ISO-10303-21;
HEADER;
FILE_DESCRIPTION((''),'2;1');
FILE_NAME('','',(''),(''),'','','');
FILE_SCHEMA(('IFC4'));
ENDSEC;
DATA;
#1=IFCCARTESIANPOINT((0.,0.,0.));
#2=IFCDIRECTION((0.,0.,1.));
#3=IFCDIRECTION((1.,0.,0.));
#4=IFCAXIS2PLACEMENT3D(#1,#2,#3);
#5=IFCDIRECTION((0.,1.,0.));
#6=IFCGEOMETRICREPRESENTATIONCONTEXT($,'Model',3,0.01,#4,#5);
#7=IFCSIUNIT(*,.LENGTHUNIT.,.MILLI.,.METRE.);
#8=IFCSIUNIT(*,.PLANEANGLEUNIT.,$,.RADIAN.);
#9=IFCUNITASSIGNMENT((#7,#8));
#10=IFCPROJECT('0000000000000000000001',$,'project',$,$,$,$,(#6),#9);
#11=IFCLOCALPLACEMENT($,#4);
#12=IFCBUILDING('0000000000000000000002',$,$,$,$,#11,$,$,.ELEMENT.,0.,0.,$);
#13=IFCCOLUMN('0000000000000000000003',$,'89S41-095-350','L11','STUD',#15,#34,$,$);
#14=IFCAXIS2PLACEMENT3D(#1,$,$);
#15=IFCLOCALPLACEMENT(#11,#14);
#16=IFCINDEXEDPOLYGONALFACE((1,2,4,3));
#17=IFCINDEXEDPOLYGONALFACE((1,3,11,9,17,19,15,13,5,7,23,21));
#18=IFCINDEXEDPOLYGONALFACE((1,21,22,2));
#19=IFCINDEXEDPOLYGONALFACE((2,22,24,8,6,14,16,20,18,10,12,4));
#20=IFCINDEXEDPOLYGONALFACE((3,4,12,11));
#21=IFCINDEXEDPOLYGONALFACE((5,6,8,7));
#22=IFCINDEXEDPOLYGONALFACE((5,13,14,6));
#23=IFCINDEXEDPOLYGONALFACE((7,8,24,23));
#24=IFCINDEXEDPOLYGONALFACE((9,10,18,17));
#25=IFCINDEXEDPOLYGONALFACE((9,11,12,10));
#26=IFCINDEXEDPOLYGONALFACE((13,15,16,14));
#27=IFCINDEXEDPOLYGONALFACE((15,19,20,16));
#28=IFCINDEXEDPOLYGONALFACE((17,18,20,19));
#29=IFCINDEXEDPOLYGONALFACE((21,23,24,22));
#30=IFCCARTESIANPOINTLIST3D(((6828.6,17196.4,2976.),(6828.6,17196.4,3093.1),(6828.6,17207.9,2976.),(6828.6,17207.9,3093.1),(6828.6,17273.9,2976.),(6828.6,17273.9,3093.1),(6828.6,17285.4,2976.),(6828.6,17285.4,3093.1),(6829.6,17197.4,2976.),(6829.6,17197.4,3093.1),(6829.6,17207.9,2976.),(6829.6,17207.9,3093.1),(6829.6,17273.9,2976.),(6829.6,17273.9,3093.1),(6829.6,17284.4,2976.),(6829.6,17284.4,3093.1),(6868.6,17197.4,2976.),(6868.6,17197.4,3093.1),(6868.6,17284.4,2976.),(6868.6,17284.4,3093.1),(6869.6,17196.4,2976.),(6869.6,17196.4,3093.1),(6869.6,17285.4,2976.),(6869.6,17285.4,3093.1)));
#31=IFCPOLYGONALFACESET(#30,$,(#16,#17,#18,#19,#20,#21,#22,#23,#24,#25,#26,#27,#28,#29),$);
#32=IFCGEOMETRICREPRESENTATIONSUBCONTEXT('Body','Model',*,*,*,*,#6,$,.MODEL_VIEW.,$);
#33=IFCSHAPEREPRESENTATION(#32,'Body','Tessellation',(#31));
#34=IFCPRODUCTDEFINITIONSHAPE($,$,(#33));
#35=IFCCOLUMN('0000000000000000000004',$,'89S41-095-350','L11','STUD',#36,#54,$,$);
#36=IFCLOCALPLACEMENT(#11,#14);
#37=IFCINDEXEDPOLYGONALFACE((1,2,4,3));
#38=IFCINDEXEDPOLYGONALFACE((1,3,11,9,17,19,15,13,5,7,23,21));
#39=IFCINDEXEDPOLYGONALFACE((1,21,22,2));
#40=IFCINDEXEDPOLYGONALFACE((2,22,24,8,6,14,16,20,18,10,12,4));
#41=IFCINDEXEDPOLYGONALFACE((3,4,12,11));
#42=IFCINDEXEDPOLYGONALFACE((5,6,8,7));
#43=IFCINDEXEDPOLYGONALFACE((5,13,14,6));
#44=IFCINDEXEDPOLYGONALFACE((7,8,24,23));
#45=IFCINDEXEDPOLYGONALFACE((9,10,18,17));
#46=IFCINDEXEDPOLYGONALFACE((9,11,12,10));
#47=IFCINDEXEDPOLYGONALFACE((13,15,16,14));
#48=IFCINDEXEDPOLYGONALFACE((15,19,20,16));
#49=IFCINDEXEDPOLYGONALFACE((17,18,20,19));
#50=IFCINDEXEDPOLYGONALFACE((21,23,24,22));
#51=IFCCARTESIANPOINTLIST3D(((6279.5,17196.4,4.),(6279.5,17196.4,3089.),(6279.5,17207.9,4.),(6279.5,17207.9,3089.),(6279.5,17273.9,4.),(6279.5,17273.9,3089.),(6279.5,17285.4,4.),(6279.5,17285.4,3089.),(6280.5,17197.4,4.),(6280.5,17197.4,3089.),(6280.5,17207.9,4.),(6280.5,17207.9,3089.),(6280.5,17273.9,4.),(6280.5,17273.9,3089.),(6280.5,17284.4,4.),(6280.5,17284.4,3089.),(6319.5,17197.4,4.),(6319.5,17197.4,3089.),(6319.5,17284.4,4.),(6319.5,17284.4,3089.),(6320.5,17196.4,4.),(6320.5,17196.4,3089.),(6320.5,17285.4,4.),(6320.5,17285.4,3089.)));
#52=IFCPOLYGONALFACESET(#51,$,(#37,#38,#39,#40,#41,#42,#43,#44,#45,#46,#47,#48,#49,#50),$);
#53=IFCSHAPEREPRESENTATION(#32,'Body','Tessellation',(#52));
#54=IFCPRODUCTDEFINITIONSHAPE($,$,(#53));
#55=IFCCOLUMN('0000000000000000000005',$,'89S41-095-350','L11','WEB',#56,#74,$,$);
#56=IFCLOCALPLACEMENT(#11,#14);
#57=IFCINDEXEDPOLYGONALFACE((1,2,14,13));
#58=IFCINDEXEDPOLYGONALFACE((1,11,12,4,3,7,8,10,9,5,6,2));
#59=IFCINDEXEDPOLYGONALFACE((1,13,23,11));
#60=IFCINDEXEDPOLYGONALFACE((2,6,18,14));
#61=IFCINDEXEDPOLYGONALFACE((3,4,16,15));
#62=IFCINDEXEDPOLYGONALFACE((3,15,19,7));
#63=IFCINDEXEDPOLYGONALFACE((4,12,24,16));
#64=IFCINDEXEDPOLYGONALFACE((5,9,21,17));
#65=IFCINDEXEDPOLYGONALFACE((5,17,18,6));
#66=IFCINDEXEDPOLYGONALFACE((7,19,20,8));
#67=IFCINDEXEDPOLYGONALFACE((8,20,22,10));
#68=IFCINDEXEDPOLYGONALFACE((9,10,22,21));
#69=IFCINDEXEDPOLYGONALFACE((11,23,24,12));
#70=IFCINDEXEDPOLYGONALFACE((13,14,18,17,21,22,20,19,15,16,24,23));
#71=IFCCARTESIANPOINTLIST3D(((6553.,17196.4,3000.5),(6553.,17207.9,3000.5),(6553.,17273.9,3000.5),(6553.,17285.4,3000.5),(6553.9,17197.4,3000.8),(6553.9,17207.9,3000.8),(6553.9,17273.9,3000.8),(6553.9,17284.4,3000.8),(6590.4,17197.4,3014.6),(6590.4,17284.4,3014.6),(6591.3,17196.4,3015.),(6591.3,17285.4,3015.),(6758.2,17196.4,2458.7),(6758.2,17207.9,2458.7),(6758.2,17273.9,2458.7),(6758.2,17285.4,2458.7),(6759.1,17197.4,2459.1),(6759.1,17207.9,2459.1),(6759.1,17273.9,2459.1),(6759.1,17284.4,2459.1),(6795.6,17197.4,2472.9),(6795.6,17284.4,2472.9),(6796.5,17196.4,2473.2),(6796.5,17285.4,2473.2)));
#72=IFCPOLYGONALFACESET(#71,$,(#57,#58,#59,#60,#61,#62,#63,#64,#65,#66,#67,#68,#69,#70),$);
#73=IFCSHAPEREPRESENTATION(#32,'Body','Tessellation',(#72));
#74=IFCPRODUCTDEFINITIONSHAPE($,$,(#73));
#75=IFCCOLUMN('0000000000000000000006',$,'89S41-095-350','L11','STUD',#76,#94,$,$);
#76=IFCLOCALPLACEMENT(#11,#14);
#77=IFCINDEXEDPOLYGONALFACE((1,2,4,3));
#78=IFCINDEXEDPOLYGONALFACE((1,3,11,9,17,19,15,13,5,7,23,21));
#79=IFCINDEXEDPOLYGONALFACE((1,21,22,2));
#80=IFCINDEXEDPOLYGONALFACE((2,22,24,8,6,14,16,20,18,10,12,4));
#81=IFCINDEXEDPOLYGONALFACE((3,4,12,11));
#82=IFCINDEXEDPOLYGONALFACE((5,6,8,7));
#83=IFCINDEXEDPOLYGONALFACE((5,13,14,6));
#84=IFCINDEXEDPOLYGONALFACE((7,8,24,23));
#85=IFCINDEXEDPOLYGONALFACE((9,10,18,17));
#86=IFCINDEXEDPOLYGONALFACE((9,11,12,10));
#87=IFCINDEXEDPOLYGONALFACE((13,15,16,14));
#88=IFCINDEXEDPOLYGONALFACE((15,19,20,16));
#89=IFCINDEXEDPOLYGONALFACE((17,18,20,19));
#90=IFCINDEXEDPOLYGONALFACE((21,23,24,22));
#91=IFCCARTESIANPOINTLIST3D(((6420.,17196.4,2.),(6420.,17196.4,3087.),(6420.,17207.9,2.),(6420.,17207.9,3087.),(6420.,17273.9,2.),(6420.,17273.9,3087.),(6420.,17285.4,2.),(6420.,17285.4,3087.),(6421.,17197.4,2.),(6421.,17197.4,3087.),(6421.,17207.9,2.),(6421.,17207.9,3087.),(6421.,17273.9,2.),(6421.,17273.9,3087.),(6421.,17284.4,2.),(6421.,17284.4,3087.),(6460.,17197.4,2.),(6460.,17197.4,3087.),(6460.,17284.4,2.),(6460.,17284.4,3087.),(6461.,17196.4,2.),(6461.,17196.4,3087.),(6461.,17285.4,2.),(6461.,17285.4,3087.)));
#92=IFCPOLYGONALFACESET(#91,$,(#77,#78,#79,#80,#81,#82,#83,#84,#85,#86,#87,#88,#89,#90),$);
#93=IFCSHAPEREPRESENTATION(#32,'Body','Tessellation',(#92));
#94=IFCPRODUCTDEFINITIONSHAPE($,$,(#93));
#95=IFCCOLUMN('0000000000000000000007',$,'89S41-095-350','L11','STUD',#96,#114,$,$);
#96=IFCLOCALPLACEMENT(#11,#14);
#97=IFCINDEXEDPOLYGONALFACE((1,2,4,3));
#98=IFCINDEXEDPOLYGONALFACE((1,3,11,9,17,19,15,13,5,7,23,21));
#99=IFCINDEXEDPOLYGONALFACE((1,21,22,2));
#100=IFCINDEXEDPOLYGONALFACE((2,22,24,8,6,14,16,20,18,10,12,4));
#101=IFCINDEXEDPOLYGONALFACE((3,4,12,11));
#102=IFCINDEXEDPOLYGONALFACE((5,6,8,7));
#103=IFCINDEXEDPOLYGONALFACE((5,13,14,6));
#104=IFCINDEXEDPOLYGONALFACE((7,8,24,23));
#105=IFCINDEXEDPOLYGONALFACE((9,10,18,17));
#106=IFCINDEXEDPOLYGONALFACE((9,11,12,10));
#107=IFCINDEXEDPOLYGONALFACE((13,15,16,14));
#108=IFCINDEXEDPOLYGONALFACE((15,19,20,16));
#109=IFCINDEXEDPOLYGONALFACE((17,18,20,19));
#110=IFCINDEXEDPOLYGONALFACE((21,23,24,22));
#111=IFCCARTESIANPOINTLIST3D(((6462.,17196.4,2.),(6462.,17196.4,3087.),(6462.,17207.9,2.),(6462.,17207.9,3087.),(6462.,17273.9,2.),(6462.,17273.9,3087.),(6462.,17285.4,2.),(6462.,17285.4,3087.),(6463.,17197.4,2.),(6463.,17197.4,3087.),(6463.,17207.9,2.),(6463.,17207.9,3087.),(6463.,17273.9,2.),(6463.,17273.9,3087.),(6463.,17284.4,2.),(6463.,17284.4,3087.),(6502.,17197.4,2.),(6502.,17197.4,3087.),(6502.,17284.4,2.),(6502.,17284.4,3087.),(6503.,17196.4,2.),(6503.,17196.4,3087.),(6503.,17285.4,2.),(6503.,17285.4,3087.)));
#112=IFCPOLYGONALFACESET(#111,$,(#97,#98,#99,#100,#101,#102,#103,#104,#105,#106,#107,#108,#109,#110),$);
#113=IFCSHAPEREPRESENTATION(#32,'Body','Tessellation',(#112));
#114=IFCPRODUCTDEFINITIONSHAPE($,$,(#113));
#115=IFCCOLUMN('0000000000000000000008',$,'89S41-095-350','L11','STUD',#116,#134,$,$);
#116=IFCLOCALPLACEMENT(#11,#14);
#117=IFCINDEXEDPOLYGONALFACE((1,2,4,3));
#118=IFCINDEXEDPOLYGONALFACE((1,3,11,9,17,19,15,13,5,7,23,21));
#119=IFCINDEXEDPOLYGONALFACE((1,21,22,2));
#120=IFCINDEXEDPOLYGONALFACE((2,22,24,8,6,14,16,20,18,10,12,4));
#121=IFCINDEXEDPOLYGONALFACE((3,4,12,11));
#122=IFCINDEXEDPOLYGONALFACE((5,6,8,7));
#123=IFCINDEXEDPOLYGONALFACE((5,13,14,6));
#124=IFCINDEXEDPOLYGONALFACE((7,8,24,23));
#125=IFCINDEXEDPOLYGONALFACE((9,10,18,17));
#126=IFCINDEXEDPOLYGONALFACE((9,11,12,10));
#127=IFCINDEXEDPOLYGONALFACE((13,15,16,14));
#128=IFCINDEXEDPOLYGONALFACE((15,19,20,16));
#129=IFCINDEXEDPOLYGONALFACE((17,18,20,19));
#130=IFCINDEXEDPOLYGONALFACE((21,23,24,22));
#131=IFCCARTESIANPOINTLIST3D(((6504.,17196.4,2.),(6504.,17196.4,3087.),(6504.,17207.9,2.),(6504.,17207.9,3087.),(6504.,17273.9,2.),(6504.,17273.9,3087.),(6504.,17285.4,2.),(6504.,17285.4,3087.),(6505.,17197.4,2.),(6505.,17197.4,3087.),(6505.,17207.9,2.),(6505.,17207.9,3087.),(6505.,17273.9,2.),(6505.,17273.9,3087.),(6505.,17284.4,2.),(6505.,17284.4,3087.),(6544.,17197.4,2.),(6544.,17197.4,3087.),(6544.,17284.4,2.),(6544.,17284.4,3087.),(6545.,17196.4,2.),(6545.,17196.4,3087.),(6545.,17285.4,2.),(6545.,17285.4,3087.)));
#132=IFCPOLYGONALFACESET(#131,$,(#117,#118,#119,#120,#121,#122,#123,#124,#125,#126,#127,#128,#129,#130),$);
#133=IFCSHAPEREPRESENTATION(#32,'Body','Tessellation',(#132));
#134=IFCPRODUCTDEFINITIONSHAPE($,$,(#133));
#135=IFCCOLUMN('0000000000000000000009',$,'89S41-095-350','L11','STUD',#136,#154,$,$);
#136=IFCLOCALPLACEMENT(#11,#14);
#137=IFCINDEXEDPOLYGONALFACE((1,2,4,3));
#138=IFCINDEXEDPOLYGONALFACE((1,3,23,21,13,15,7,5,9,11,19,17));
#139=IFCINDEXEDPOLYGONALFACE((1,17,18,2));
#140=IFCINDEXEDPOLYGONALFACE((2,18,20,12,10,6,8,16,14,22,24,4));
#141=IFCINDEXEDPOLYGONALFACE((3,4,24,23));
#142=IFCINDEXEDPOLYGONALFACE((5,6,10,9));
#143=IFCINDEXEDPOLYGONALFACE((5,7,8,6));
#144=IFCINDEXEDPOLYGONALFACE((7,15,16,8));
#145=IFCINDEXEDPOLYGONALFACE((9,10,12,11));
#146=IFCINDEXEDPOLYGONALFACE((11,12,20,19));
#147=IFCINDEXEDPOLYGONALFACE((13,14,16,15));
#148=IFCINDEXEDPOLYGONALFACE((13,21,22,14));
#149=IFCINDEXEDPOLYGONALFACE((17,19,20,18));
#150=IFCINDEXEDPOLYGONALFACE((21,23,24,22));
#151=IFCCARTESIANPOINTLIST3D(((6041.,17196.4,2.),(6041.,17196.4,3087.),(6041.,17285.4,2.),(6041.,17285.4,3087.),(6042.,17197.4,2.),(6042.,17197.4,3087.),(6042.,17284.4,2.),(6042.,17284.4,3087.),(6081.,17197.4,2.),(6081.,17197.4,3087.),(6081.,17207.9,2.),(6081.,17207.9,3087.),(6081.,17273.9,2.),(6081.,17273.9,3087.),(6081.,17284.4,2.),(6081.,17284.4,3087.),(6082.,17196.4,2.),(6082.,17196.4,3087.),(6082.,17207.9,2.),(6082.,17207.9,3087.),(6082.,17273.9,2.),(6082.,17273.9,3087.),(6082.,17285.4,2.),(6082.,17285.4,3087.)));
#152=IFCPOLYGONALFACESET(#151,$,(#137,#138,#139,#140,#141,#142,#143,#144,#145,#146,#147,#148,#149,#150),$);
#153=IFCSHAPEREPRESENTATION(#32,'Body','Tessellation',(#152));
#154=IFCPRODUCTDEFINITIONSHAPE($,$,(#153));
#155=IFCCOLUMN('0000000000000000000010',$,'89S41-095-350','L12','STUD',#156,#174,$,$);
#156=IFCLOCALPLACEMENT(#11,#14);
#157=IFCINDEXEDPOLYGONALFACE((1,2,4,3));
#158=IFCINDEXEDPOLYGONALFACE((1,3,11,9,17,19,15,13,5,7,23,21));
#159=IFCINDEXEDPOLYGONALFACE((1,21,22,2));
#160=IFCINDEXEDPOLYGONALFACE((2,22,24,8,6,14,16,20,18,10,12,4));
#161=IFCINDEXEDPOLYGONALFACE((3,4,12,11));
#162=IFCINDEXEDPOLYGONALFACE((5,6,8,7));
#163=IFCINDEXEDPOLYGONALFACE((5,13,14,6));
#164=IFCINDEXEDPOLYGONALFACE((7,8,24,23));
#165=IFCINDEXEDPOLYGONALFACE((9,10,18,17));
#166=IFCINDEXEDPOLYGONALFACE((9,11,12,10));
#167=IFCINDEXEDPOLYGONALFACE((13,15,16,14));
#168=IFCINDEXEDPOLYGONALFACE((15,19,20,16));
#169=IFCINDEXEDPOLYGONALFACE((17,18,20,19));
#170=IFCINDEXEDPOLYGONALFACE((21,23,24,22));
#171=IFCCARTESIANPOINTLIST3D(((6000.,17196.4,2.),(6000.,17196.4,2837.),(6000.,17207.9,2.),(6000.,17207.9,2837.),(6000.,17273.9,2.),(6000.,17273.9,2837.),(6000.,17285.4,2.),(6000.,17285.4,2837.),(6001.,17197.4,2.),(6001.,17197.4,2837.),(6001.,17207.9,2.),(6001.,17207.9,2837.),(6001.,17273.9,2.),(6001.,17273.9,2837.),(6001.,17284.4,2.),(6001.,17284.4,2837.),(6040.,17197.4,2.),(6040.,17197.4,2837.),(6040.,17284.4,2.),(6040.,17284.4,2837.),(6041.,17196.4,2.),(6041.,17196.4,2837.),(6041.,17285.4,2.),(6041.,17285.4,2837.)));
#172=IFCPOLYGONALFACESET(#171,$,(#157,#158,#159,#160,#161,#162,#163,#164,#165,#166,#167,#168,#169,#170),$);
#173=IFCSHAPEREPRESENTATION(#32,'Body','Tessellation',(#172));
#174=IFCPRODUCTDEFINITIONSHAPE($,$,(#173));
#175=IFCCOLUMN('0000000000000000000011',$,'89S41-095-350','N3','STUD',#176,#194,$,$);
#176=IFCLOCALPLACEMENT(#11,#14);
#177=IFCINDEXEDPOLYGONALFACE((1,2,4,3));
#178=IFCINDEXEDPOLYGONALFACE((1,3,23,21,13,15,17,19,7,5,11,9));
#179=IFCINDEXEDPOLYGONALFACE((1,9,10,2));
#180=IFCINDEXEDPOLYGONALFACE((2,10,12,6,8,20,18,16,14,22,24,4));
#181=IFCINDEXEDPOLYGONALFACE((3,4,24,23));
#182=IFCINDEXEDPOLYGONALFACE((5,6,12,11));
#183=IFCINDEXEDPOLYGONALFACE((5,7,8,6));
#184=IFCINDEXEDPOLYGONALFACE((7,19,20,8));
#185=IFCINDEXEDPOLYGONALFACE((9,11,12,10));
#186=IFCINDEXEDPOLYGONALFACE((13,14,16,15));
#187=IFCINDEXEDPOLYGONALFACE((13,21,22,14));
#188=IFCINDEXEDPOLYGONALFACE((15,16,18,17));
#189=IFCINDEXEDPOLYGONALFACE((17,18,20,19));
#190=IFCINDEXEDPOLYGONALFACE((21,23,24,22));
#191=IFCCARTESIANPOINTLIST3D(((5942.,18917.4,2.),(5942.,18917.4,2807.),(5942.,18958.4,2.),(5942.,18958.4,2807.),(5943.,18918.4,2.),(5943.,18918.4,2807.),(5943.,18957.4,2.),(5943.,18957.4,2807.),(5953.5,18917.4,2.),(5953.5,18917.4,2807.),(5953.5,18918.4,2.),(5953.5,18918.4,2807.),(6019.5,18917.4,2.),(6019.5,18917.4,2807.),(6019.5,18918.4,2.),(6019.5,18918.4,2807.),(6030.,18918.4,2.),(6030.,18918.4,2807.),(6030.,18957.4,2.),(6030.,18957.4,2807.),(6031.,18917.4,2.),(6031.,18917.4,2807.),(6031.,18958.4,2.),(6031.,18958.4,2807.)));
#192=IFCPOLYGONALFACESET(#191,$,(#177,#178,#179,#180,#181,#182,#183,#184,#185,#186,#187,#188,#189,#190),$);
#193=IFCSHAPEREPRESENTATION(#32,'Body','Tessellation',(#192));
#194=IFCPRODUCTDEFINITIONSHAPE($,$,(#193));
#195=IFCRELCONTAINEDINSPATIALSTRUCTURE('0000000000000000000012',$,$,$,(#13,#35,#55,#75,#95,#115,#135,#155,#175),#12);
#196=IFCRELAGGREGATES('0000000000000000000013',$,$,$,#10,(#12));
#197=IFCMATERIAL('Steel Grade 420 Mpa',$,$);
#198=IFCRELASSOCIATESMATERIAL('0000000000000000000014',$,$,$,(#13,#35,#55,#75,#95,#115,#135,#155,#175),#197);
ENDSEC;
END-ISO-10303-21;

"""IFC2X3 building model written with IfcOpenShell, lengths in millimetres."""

from ifc_helpers import new_model, si_unit, direction, frame, origin, origin_with_axes, origin_2d_with_axis, place, context, subcontext, project, spatial, c_section, extrude, source, transform, mapped, material, element, save


model = new_model("IFC2X3")

# Units and contexts
model_context = context("Model", 3, precision=0.01, world=origin_with_axes(), true_north=direction((0.0, 1.0, 0.0)))
body_context = subcontext(model_context, "Body", "Model", "MODEL_VIEW")
ifc_project = project(units=[si_unit("LENGTHUNIT", "METRE", prefix="MILLI"), si_unit("PLANEANGLEUNIT", "RADIAN")], contexts=[model_context])

# Building
building_placement = place(None, origin_with_axes())
building = spatial("IfcBuilding", under=ifc_project, at=building_placement, CompositionType="ELEMENT", ElevationOfRefHeight=0.0, ElevationOfTerrain=0.0)

# Columns
ifc_material = material(Name="Steel Grade 420 Mpa")
shared_shape_1 = source(origin(), body_context, "Body", "SweptSolid", [
    extrude(c_section(Depth=89.0, Width=41.0, WallThickness=1.0, Girth=11.5, at=origin_2d_with_axis()), origin_with_axes(), (0.0, 0.0, 1.0), 117.1),
])
column_1_placement = place(None, frame((6849.1, 17240.9, 2976.0), z_axis=(0.0, 0.0, 1.0), x_axis=(-1.0, 0.0, 0.0)))
element("IfcColumn", 1, at=column_1_placement, inside=building, material=ifc_material, Name="89S41-095-350", Description="L11", ObjectType="STUD", context=body_context, shape_type="MappedRepresentation", body=[
    mapped(shared_shape_1, transform((0.0, 0.0, 0.0), scale=1.0)),
])
shared_shape_2 = source(origin(), body_context, "Body", "SweptSolid", [
    extrude(c_section(Depth=89.0, Width=41.0, WallThickness=1.0, Girth=11.5, at=origin_2d_with_axis()), origin_with_axes(), (0.0, 0.0, 1.0), 3085.0),
])
column_2_placement = place(None, frame((6300.0, 17240.9, 4.0), z_axis=(0.0, 0.0, 1.0), x_axis=(-1.0, 0.0, 0.0)))
element("IfcColumn", 2, at=column_2_placement, inside=building, material=ifc_material, Name="89S41-095-350", Description="L11", ObjectType="STUD", context=body_context, shape_type="MappedRepresentation", body=[
    mapped(shared_shape_2, transform((0.0, 0.0, 0.0), scale=1.0)),
])
shared_shape_3 = source(origin(), body_context, "Body", "SweptSolid", [
    extrude(c_section(Depth=89.0, Width=41.0, WallThickness=1.0, Girth=11.5, at=origin_2d_with_axis()), origin_with_axes(), (0.0, 0.0, 1.0), 579.3),
])
column_3_placement = place(None, frame((6572.1, 17240.9, 3007.7), z_axis=(0.354194, 0.0, -0.935172), x_axis=(-0.935172, 0.0, -0.354194)))
element("IfcColumn", 3, at=column_3_placement, inside=building, material=ifc_material, Name="89S41-095-350", Description="L11", ObjectType="WEB", context=body_context, shape_type="MappedRepresentation", body=[
    mapped(shared_shape_3, transform((0.0, 0.0, 0.0), scale=1.0)),
])
shared_shape_4 = source(origin(), body_context, "Body", "SweptSolid", [
    extrude(c_section(Depth=89.0, Width=41.0, WallThickness=1.0, Girth=11.5, at=origin_2d_with_axis()), origin_with_axes(), (0.0, 0.0, 1.0), 3085.0),
])
column_4_placement = place(None, frame((6440.5, 17240.9, 2.0), z_axis=(0.0, 0.0, 1.0), x_axis=(-1.0, 0.0, 0.0)))
element("IfcColumn", 4, at=column_4_placement, inside=building, material=ifc_material, Name="89S41-095-350", Description="L11", ObjectType="STUD", context=body_context, shape_type="MappedRepresentation", body=[
    mapped(shared_shape_4, transform((0.0, 0.0, 0.0), scale=1.0)),
])
shared_shape_5 = source(origin(), body_context, "Body", "SweptSolid", [
    extrude(c_section(Depth=89.0, Width=41.0, WallThickness=1.0, Girth=11.5, at=origin_2d_with_axis()), origin_with_axes(), (0.0, 0.0, 1.0), 3085.0),
])
column_5_placement = place(None, frame((6482.5, 17240.9, 2.0), z_axis=(0.0, 0.0, 1.0), x_axis=(-1.0, 0.0, 0.0)))
element("IfcColumn", 5, at=column_5_placement, inside=building, material=ifc_material, Name="89S41-095-350", Description="L11", ObjectType="STUD", context=body_context, shape_type="MappedRepresentation", body=[
    mapped(shared_shape_5, transform((0.0, 0.0, 0.0), scale=1.0)),
])
shared_shape_6 = source(origin(), body_context, "Body", "SweptSolid", [
    extrude(c_section(Depth=89.0, Width=41.0, WallThickness=1.0, Girth=11.5, at=origin_2d_with_axis()), origin_with_axes(), (0.0, 0.0, 1.0), 3085.0),
])
column_6_placement = place(None, frame((6524.5, 17240.9, 2.0), z_axis=(0.0, 0.0, 1.0), x_axis=(-1.0, 0.0, 0.0)))
element("IfcColumn", 6, at=column_6_placement, inside=building, material=ifc_material, Name="89S41-095-350", Description="L11", ObjectType="STUD", context=body_context, shape_type="MappedRepresentation", body=[
    mapped(shared_shape_6, transform((0.0, 0.0, 0.0), scale=1.0)),
])
shared_shape_7 = source(origin(), body_context, "Body", "SweptSolid", [
    extrude(c_section(Depth=89.0, Width=41.0, WallThickness=1.0, Girth=11.5, at=origin_2d_with_axis()), origin_with_axes(), (0.0, 0.0, 1.0), 3085.0),
])
column_7_placement = place(None, frame((6061.5, 17240.9, 2.0), z_axis=(0.0, 0.0, 1.0), x_axis=(1.0, 0.0, 0.0)))
element("IfcColumn", 7, at=column_7_placement, inside=building, material=ifc_material, Name="89S41-095-350", Description="L11", ObjectType="STUD", context=body_context, shape_type="MappedRepresentation", body=[
    mapped(shared_shape_7, transform((0.0, 0.0, 0.0), scale=1.0)),
])
shared_shape_8 = source(origin(), body_context, "Body", "SweptSolid", [
    extrude(c_section(Depth=89.0, Width=41.0, WallThickness=1.0, Girth=11.5, at=origin_2d_with_axis()), origin_with_axes(), (0.0, 0.0, 1.0), 2835.0),
])
column_8_placement = place(None, frame((6020.5, 17240.9, 2.0), z_axis=(0.0, 0.0, 1.0), x_axis=(-1.0, 0.0, 0.0)))
element("IfcColumn", 8, at=column_8_placement, inside=building, material=ifc_material, Name="89S41-095-350", Description="L12", ObjectType="STUD", context=body_context, shape_type="MappedRepresentation", body=[
    mapped(shared_shape_8, transform((0.0, 0.0, 0.0), scale=1.0)),
])
shared_shape_9 = source(origin(), body_context, "Body", "SweptSolid", [
    extrude(c_section(Depth=89.0, Width=41.0, WallThickness=1.0, Girth=11.5, at=origin_2d_with_axis()), origin_with_axes(), (0.0, 0.0, 1.0), 2805.0),
])
column_9_placement = place(None, frame((5986.5, 18937.9, 2.0), z_axis=(0.0, 0.0, 1.0), x_axis=(0.0, -1.0, 0.0)))
element("IfcColumn", 9, at=column_9_placement, inside=building, material=ifc_material, Name="89S41-095-350", Description="N3", ObjectType="STUD", context=body_context, shape_type="MappedRepresentation", body=[
    mapped(shared_shape_9, transform((0.0, 0.0, 0.0), scale=1.0)),
])

save(model, "model.ifc")
